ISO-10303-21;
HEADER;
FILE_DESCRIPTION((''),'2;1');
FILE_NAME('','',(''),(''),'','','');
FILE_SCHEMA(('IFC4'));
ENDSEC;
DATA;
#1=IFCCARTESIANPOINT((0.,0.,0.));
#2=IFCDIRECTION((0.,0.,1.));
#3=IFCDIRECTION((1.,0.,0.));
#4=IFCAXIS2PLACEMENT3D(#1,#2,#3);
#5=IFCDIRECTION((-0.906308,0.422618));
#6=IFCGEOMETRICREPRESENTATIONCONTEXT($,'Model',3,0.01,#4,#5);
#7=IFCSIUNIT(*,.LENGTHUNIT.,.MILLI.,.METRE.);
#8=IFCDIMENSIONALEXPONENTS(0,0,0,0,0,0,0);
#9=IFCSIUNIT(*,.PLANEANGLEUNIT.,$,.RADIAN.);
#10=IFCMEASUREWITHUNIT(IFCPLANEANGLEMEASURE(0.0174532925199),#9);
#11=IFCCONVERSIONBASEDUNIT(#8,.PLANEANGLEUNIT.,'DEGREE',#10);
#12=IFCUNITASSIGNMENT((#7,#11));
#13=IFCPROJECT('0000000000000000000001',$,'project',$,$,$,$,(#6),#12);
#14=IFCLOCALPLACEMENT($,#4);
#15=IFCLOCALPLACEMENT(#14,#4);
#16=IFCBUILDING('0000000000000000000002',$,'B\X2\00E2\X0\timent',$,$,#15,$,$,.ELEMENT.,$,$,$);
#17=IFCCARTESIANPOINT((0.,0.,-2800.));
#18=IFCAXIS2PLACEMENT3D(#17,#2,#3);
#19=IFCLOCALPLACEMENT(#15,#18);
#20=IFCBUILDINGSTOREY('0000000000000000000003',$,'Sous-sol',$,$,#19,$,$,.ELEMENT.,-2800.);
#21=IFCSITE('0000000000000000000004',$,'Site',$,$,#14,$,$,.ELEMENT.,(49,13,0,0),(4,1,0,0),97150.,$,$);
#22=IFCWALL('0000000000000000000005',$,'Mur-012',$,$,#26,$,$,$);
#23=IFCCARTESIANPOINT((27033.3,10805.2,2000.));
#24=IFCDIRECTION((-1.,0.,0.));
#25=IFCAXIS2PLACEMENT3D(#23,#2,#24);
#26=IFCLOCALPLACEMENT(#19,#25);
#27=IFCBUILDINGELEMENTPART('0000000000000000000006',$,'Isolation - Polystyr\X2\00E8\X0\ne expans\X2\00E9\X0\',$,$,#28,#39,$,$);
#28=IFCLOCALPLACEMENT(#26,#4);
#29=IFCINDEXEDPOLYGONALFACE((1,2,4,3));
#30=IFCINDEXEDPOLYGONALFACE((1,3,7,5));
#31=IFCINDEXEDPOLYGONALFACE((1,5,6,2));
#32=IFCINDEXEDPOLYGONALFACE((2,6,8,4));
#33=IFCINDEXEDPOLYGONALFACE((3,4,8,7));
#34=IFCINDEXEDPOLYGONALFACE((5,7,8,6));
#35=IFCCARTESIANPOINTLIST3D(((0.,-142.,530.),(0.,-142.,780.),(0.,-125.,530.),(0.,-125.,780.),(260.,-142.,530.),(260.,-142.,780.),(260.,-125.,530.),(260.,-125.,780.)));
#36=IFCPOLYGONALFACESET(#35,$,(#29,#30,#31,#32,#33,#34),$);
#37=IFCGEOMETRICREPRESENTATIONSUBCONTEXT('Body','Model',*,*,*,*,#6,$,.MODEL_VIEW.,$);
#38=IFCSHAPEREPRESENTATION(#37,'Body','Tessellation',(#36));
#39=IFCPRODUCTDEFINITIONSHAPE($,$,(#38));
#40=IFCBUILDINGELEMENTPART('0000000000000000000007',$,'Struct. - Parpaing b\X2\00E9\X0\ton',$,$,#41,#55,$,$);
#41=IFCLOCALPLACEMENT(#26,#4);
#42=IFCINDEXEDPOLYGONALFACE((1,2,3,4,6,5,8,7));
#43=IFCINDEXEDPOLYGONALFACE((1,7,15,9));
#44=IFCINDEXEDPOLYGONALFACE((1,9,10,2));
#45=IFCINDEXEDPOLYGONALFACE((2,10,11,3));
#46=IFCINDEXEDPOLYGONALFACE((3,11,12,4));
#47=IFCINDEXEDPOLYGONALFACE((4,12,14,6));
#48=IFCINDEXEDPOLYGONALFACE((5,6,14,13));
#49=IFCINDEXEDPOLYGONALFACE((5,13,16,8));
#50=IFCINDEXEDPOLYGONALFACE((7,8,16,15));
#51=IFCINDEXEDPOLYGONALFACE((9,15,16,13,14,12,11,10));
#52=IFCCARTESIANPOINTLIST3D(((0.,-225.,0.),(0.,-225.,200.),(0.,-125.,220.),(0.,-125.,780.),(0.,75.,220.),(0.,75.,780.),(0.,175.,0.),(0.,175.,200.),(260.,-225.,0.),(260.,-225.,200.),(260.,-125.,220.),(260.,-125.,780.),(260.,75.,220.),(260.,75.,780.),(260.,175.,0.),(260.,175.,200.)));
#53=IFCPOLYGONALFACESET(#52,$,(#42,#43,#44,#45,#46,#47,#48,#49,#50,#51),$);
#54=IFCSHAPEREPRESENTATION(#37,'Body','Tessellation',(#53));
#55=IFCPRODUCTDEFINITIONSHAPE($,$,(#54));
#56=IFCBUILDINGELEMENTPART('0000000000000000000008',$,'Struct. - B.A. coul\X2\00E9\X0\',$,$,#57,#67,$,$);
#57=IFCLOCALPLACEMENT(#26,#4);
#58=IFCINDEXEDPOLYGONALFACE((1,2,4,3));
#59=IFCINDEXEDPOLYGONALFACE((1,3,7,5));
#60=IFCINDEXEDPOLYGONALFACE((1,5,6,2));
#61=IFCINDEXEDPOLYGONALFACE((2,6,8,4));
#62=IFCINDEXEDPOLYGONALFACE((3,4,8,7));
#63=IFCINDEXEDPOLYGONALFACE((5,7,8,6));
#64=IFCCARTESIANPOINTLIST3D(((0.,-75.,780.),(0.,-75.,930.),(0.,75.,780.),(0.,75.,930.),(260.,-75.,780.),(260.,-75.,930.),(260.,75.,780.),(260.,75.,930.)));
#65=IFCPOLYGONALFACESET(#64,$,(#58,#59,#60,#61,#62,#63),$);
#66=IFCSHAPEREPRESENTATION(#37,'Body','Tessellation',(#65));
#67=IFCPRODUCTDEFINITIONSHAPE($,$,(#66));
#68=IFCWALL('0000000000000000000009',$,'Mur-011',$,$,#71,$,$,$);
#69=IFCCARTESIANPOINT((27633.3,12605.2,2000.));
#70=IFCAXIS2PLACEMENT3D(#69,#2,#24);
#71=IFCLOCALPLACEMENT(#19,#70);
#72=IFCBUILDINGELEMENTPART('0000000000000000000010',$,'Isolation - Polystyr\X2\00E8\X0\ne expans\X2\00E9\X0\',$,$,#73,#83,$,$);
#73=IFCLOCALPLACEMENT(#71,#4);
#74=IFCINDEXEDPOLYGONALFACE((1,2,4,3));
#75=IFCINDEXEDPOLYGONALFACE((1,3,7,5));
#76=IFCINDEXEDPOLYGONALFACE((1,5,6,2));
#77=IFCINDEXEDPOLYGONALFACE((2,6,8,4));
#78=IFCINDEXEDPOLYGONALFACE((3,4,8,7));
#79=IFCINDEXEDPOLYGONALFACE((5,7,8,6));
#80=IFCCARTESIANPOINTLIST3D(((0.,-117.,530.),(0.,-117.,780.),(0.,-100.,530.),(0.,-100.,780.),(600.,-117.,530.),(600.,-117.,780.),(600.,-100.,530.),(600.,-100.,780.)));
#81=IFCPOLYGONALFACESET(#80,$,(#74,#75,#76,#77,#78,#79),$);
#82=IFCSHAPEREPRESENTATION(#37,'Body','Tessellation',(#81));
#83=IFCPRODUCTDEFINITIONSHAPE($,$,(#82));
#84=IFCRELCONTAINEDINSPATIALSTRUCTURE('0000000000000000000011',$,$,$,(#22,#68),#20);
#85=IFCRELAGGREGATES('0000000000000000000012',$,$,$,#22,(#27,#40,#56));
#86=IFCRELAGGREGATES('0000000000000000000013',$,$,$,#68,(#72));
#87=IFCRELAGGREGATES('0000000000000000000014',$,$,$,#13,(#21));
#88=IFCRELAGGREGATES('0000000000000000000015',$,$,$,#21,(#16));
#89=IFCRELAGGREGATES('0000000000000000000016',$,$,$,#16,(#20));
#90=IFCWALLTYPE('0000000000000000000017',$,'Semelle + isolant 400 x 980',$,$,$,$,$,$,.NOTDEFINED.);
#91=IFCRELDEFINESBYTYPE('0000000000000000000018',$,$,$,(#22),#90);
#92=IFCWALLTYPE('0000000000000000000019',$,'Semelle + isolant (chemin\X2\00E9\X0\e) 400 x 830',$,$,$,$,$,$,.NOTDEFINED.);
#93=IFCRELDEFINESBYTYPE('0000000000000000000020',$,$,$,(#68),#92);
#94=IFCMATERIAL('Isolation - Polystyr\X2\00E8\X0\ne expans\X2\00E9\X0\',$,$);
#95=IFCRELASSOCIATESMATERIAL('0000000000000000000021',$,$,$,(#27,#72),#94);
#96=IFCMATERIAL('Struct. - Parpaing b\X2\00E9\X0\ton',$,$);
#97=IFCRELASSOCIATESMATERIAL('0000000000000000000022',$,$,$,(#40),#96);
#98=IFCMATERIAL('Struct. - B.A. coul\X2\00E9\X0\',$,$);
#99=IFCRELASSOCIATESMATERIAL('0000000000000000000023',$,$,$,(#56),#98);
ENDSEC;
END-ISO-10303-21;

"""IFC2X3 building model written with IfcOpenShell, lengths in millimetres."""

from ifc_helpers import new_model, entity, si_unit, converted_unit, direction, frame, origin_with_axes, place, context, subcontext, project, spatial, polyline, outline, extrude, material, type_object, element, aggregate, save


model = new_model("IFC2X3")

# Units and contexts
model_context = context("Model", 3, precision=0.01, world=origin_with_axes(), true_north=direction((-0.906308, 0.422618)))
body_context = subcontext(model_context, "Body", "Model", "MODEL_VIEW")
ifc_project = project(units=[si_unit("LENGTHUNIT", "METRE", prefix="MILLI"), converted_unit("PLANEANGLEUNIT", "DEGREE", entity("IfcPlaneAngleMeasure", 0.0174532925199), si_unit("PLANEANGLEUNIT", "RADIAN"), dimensions=[0, 0, 0, 0, 0, 0, 0])], contexts=[model_context])

# Site, building, storey
site_placement = place(None, origin_with_axes())
site = spatial("IfcSite", under=ifc_project, at=site_placement, Name="Site", CompositionType="ELEMENT", RefLatitude=(49, 13, 0, 0), RefLongitude=(4, 1, 0, 0), RefElevation=97150.0)
building_placement = place(site_placement, origin_with_axes())
building = spatial("IfcBuilding", under=site, at=building_placement, Name="Bâtiment", CompositionType="ELEMENT")
storey_placement = place(building_placement, frame((0.0, 0.0, -2800.0), z_axis=(0.0, 0.0, 1.0), x_axis=(1.0, 0.0, 0.0)))
storey = spatial("IfcBuildingStorey", under=building, at=storey_placement, Name="Sous-sol", CompositionType="ELEMENT", Elevation=-2800.0)

# Shared definitions
ifc_material_1 = material(Name="Struct. - Parpaing béton")
wall_type_1 = type_object("IfcWallType", Name="Semelle + isolant (cheminée) 400 x 830", PredefinedType="NOTDEFINED")
ifc_material_2 = material(Name="Isolation - Polystyrène expansé")
wall_type_2 = type_object("IfcWallType", Name="Semelle + isolant 400 x 980", PredefinedType="NOTDEFINED")
ifc_material_3 = material(Name="Struct. - B.A. coulé")

# Walls, building element parts
wall_1_placement = place(storey_placement, frame((27033.3, 10805.2, 2000.0), z_axis=(0.0, 0.0, 1.0), x_axis=(-1.0, 0.0, 0.0)))
wall_1 = element("IfcWall", 1, at=wall_1_placement, inside=storey, type_object=wall_type_2, Name="Mur-012")
building_element_part_1_placement = place(wall_1_placement, origin_with_axes())
building_element_part_1 = element("IfcBuildingElementPart", 2, at=building_element_part_1_placement, material=ifc_material_2, Name="Isolation - Polystyrène expansé", context=body_context, shape_type="SweptSolid", body=[
    extrude(outline(polyline([(125.0, 780.0), (125.0, 530.0), (142.0, 530.0), (142.0, 780.0), (125.0, 780.0)])), frame((0.0, 0.0, 0.0), z_axis=(-1.0, 0.0, 0.0), x_axis=(0.0, -1.0, 0.0)), (0.0, 0.0, -1.0), 260.0),
])
building_element_part_2_placement = place(wall_1_placement, origin_with_axes())
building_element_part_2 = element("IfcBuildingElementPart", 3, at=building_element_part_2_placement, material=ifc_material_1, Name="Struct. - Parpaing béton", context=body_context, shape_type="SweptSolid", body=[
    extrude(outline(polyline([(-75.0, 220.0), (-175.0, 200.0), (-175.0, 0.0), (225.0, 0.0), (225.0, 200.0), (125.0, 220.0), (125.0, 780.0), (-75.0, 780.0), (-75.0, 220.0)])), frame((0.0, 0.0, 0.0), z_axis=(-1.0, 0.0, 0.0), x_axis=(0.0, -1.0, 0.0)), (0.0, 0.0, -1.0), 260.0),
])
building_element_part_3_placement = place(wall_1_placement, origin_with_axes())
building_element_part_3 = element("IfcBuildingElementPart", 4, at=building_element_part_3_placement, material=ifc_material_3, Name="Struct. - B.A. coulé", context=body_context, shape_type="SweptSolid", body=[
    extrude(outline(polyline([(75.0, 780.0), (75.0, 930.0), (-75.0, 930.0), (-75.0, 780.0), (75.0, 780.0)])), frame((0.0, 0.0, 0.0), z_axis=(-1.0, 0.0, 0.0), x_axis=(0.0, -1.0, 0.0)), (0.0, 0.0, -1.0), 260.0),
])
aggregate(wall_1, [building_element_part_1, building_element_part_2, building_element_part_3])
wall_2_placement = place(storey_placement, frame((27633.3, 12605.2, 2000.0), z_axis=(0.0, 0.0, 1.0), x_axis=(-1.0, 0.0, 0.0)))
wall_2 = element("IfcWall", 5, at=wall_2_placement, inside=storey, type_object=wall_type_1, Name="Mur-011")
building_element_part_4_placement = place(wall_2_placement, origin_with_axes())
building_element_part_4 = element("IfcBuildingElementPart", 6, at=building_element_part_4_placement, material=ifc_material_2, Name="Isolation - Polystyrène expansé", context=body_context, shape_type="SweptSolid", body=[
    extrude(outline(polyline([(100.0, 780.0), (100.0, 530.0), (117.0, 530.0), (117.0, 780.0), (100.0, 780.0)])), frame((0.0, 0.0, 0.0), z_axis=(-1.0, 0.0, 0.0), x_axis=(0.0, -1.0, 0.0)), (0.0, 0.0, -1.0), 600.0),
])
aggregate(wall_2, [building_element_part_4])

save(model, "model.ifc")
